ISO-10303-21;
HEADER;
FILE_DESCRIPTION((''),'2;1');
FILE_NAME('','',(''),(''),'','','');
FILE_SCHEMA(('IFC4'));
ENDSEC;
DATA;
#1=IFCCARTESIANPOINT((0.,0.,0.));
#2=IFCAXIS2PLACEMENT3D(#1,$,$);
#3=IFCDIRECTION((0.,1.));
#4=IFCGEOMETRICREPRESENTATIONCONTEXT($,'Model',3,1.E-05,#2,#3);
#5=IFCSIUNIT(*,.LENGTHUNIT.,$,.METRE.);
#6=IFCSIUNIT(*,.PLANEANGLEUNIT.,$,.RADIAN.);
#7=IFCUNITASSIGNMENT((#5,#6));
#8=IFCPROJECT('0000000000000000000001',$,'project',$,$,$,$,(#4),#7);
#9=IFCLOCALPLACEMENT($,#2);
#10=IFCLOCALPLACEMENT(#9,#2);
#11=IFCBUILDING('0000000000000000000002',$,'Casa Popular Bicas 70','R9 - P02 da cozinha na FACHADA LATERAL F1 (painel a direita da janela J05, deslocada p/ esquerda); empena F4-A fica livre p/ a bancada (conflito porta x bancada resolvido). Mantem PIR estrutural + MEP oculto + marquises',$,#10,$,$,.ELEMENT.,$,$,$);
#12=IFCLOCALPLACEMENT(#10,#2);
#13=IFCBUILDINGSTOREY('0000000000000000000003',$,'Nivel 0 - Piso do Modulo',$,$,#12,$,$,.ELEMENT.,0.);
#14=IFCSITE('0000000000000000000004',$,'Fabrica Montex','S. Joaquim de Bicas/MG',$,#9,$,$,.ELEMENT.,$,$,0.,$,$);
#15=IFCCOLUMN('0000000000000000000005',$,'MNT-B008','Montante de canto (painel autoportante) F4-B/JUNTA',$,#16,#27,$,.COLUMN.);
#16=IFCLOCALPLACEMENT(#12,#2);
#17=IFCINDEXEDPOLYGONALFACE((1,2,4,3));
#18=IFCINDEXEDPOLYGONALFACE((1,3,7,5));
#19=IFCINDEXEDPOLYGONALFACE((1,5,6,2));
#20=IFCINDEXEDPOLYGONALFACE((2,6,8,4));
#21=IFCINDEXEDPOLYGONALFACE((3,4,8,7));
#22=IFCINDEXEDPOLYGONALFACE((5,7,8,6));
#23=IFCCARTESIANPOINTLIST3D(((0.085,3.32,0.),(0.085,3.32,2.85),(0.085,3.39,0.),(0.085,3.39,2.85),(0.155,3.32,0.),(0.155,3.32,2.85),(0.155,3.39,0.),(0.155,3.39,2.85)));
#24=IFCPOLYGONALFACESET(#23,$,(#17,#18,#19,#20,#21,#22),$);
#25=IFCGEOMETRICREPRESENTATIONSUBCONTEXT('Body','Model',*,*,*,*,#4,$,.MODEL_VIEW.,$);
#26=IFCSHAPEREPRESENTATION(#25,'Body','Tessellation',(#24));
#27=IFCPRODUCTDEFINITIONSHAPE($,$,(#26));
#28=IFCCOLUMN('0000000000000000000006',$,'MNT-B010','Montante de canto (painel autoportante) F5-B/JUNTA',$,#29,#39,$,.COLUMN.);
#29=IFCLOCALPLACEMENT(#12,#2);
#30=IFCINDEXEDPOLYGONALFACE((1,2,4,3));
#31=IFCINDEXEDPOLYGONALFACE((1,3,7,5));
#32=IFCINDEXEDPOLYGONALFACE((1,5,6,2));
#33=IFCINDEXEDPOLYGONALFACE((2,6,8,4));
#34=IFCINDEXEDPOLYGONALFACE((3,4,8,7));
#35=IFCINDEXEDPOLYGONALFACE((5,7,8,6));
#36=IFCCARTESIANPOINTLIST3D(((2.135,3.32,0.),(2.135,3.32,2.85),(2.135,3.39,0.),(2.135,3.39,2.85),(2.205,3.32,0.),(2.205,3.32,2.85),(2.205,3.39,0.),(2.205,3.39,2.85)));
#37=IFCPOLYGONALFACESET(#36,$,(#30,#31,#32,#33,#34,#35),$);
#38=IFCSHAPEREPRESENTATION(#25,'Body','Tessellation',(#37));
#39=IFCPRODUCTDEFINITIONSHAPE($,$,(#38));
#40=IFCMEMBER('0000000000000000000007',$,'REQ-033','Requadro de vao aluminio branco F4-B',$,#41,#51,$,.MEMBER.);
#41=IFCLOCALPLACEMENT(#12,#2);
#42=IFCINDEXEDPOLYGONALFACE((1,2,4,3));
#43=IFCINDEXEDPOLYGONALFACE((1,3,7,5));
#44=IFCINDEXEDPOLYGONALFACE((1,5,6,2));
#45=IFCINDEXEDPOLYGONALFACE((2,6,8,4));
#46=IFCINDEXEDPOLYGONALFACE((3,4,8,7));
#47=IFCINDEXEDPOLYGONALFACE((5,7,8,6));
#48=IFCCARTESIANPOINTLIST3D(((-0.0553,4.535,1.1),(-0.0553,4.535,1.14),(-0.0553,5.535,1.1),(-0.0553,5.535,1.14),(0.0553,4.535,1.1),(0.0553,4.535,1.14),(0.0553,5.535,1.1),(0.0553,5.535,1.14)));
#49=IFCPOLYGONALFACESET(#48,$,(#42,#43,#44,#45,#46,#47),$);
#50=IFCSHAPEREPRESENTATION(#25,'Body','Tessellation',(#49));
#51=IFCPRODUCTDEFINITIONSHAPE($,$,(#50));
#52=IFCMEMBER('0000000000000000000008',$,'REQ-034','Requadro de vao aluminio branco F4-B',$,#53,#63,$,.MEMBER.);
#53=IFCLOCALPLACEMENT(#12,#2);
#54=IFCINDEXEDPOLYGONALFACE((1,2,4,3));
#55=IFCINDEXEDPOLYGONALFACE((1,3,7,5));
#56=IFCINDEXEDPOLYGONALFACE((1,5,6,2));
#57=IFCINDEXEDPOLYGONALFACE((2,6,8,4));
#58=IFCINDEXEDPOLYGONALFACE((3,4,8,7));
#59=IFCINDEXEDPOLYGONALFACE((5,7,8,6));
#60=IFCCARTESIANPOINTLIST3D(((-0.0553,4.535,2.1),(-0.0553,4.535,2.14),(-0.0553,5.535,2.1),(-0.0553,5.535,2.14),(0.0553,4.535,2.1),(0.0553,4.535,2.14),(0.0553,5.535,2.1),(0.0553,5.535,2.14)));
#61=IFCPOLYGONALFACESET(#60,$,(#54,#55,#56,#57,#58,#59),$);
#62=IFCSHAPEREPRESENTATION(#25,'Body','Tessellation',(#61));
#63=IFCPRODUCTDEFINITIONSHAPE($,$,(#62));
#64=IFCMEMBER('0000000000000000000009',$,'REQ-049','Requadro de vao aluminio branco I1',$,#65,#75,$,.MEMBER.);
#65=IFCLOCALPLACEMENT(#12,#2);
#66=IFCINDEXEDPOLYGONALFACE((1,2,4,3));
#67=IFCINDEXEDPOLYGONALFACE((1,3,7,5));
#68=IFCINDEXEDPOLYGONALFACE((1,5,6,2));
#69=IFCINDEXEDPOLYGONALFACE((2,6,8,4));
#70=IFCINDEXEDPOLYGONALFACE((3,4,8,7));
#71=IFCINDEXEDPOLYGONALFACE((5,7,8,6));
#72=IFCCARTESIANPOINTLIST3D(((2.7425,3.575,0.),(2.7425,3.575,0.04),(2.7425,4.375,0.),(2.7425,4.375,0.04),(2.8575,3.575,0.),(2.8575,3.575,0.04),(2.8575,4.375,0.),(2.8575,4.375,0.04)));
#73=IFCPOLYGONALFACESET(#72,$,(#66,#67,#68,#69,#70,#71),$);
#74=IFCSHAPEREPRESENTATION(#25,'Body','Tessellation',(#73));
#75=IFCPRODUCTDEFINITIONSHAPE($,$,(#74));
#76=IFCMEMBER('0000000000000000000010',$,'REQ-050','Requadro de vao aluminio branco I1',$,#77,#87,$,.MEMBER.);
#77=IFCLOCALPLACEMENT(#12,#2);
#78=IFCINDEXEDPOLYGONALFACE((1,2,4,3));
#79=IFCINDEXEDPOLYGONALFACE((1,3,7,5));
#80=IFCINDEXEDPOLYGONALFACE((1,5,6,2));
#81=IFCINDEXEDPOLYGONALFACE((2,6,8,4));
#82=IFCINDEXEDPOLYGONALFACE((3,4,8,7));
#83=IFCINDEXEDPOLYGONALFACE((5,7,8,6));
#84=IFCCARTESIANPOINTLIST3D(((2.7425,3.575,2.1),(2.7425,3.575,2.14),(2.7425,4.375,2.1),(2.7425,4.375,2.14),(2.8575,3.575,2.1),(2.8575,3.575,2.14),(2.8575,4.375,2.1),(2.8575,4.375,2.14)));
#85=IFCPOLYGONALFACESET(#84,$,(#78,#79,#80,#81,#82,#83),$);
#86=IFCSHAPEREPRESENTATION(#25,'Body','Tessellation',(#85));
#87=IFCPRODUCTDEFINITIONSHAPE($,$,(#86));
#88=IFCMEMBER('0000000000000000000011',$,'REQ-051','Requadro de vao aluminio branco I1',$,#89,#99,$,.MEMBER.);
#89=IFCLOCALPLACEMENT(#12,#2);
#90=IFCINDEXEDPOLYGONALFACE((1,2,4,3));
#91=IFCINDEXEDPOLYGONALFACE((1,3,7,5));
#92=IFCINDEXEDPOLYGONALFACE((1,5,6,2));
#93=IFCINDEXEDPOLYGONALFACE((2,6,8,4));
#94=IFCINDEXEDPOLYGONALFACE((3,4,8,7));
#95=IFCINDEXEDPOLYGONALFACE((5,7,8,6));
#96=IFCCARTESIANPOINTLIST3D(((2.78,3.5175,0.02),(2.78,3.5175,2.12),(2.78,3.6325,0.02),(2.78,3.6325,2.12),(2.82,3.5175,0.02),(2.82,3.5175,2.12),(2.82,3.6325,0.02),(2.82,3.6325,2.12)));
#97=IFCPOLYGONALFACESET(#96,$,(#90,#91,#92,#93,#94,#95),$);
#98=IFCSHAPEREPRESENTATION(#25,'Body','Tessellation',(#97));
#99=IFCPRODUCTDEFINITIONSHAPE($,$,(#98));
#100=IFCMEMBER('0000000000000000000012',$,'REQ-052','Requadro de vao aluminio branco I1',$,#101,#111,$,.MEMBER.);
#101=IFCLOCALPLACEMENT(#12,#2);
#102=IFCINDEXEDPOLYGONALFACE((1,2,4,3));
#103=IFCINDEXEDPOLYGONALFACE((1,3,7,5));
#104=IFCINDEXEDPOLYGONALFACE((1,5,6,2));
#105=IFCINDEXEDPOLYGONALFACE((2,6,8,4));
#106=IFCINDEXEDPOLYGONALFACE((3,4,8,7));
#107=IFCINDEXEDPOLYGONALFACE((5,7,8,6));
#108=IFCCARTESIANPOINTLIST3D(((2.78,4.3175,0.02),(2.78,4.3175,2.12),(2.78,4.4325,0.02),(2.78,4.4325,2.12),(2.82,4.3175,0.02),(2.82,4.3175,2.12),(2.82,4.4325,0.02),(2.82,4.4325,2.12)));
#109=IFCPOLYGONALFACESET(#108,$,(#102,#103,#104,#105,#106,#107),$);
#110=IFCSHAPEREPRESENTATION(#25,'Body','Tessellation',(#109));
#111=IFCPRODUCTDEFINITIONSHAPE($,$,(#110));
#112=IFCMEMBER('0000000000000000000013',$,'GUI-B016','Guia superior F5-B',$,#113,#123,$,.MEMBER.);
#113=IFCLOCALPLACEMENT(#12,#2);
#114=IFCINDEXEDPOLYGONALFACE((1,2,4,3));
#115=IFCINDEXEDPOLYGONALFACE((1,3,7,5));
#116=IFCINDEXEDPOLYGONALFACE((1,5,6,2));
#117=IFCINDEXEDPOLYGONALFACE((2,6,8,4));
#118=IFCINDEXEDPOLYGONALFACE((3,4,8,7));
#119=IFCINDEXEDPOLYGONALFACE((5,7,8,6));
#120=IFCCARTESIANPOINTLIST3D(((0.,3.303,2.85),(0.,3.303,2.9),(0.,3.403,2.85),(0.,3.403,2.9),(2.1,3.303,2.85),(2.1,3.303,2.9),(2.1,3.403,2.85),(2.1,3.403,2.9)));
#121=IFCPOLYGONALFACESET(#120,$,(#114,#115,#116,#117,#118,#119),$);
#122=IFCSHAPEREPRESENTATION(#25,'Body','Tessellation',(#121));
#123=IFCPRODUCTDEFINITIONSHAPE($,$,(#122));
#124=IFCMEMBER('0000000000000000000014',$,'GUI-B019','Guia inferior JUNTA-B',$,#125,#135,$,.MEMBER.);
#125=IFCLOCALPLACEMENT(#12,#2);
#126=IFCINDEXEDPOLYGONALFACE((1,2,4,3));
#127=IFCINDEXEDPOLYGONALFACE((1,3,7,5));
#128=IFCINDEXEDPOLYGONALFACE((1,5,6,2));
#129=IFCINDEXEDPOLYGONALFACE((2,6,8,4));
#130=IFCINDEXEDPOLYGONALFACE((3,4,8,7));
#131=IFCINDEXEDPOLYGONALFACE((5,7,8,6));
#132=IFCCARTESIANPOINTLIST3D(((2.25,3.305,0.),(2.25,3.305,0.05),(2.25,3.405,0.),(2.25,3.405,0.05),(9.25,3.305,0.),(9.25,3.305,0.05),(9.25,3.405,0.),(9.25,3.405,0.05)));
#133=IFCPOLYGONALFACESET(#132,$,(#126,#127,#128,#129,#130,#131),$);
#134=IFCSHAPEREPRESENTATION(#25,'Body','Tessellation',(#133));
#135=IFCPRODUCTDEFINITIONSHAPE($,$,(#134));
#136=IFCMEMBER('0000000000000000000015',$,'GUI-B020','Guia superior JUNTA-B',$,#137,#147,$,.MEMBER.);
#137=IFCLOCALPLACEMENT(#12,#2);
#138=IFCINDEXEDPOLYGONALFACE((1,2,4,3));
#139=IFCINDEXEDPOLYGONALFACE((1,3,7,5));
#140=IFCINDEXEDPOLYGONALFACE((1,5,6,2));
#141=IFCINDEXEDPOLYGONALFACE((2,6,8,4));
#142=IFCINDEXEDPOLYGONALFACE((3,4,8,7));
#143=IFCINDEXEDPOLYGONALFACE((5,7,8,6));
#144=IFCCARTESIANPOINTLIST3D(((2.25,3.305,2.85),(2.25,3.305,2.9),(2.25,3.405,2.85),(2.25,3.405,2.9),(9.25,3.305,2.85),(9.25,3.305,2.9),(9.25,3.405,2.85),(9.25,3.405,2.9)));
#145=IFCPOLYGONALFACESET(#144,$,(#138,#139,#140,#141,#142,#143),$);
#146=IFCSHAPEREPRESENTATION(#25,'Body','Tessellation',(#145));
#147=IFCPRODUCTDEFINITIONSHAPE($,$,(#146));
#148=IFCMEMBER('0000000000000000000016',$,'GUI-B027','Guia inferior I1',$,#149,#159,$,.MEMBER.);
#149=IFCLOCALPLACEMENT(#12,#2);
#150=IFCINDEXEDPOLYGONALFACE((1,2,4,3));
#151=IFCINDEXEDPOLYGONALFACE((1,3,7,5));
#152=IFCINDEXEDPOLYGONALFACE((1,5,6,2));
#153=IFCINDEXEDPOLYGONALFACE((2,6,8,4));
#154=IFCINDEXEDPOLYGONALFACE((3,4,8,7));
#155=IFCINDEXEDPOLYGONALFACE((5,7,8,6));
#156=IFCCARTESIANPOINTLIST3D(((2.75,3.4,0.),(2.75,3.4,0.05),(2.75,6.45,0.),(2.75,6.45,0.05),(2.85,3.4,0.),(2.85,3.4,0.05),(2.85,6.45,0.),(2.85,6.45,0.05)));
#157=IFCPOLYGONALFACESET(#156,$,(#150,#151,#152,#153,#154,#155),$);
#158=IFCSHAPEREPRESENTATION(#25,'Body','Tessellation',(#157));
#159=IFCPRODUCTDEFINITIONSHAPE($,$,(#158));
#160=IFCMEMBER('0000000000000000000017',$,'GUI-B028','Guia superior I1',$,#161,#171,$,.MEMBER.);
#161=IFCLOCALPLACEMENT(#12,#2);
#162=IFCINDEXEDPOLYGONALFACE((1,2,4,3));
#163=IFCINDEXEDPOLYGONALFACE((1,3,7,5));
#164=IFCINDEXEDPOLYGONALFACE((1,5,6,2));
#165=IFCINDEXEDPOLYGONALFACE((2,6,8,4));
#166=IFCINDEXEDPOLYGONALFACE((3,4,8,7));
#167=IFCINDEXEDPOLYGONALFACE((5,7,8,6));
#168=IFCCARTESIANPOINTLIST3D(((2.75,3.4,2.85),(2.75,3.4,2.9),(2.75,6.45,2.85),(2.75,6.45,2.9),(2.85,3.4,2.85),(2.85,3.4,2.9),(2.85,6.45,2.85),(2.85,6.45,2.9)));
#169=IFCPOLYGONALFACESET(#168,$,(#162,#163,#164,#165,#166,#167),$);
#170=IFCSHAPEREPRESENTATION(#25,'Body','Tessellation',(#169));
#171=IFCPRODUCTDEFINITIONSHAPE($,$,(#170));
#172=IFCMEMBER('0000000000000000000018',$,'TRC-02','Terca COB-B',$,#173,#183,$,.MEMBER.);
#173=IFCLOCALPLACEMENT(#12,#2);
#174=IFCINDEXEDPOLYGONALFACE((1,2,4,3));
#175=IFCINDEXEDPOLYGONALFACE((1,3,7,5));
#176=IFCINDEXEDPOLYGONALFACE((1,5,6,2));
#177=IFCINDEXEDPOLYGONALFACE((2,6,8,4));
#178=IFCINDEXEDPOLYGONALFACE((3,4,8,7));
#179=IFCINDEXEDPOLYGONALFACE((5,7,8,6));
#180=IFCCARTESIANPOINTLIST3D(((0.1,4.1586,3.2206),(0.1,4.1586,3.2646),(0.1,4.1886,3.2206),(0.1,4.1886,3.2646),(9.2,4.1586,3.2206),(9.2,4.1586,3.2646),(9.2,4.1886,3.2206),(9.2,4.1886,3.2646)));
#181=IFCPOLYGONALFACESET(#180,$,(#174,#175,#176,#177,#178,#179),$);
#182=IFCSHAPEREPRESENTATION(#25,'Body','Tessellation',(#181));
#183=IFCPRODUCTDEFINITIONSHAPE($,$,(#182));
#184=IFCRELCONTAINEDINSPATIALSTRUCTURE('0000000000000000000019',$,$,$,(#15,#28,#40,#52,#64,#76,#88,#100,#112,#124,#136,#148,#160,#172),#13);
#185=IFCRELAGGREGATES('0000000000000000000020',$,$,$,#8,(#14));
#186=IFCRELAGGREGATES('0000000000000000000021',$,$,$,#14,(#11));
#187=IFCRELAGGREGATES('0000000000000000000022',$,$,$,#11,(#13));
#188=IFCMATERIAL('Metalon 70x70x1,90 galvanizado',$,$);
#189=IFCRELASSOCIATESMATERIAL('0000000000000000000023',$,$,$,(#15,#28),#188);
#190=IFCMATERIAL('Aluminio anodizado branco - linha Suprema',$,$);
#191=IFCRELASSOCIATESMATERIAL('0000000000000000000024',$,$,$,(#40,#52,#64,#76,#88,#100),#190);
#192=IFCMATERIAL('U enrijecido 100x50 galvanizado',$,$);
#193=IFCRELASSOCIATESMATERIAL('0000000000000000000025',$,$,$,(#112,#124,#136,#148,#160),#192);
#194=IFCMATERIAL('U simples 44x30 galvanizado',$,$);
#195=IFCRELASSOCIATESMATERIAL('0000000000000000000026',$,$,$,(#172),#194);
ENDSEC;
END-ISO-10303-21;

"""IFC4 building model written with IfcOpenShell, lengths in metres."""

from ifc_helpers import new_model, si_unit, direction, frame, origin, origin_2d, place, context, subcontext, project, spatial, rectangle, extrude, material, element, save


model = new_model("IFC4")

# Units and contexts
model_context = context("Model", 3, precision=1e-05, world=origin(), true_north=direction((0.0, 1.0)))
body_context = subcontext(model_context, "Body", "Model", "MODEL_VIEW")
ifc_project = project(units=[si_unit("LENGTHUNIT", "METRE"), si_unit("PLANEANGLEUNIT", "RADIAN")], contexts=[model_context])

# Site, building, storey
site_placement = place(None, origin())
site = spatial("IfcSite", under=ifc_project, at=site_placement, Name="Fabrica Montex", Description="S. Joaquim de Bicas/MG", CompositionType="ELEMENT", RefElevation=0.0)
building_placement = place(site_placement, origin())
building = spatial("IfcBuilding", under=site, at=building_placement, Name="Casa Popular Bicas 70", Description="R9 - P02 da cozinha na FACHADA LATERAL F1 (painel a direita da janela J05, deslocada p/ esquerda); empena F4-A fica livre p/ a bancada (conflito porta x bancada resolvido). Mantem PIR estrutural + MEP oculto + marquises", CompositionType="ELEMENT")
storey_placement = place(building_placement, origin())
storey = spatial("IfcBuildingStorey", under=building, at=storey_placement, Name="Nivel 0 - Piso do Modulo", CompositionType="ELEMENT", Elevation=0.0)

# Columns
ifc_material_1 = material(Name="Metalon 70x70x1,90 galvanizado")
for number, where, name, description in (
    (1, (0.12, 3.355, 0.0), "MNT-B008", "Montante de canto (painel autoportante) F4-B/JUNTA"),
    (2, (2.17, 3.355, 0.0), "MNT-B010", "Montante de canto (painel autoportante) F5-B/JUNTA"),
):
    element("IfcColumn", number, at=place(storey_placement, frame(where)), inside=storey, material=ifc_material_1, Name=name, Description=description, PredefinedType="COLUMN", context=body_context, shape_type="SweptSolid", body=[
        extrude(rectangle(XDim=0.07, YDim=0.07, at=origin_2d()), origin(), (0.0, 0.0, 1.0), 2.85),
    ])

# Members
ifc_material_2 = material(Name="Aluminio anodizado branco - linha Suprema")
for number, where, z_axis, x_axis, name in (
    (3, (0.0, 4.535, 1.12), (0.0, 1.0, 0.0), (0.0, 0.0, 1.0), "REQ-033"),
    (4, (0.0, 4.535, 2.12), (0.0, 1.0, 0.0), (0.0, 0.0, 1.0), "REQ-034"),
):
    element("IfcMember", number, at=place(storey_placement, frame(where, z_axis=z_axis, x_axis=x_axis)), inside=storey, material=ifc_material_2, Name=name, Description="Requadro de vao aluminio branco F4-B", PredefinedType="MEMBER", context=body_context, shape_type="SweptSolid", body=[
        extrude(rectangle(XDim=0.04, YDim=0.1105, at=origin_2d()), origin(), (0.0, 0.0, 1.0), 1.0),
    ])
for number, where, z_axis, x_axis, name in (
    (5, (2.8, 3.575, 0.02), (0.0, 1.0, 0.0), (0.0, 0.0, 1.0), "REQ-049"),
    (6, (2.8, 3.575, 2.12), (0.0, 1.0, 0.0), (0.0, 0.0, 1.0), "REQ-050"),
):
    element("IfcMember", number, at=place(storey_placement, frame(where, z_axis=z_axis, x_axis=x_axis)), inside=storey, material=ifc_material_2, Name=name, Description="Requadro de vao aluminio branco I1", PredefinedType="MEMBER", context=body_context, shape_type="SweptSolid", body=[
        extrude(rectangle(XDim=0.04, YDim=0.115, at=origin_2d()), origin(), (0.0, 0.0, 1.0), 0.8),
    ])
for number, where, z_axis, x_axis, name in (
    (7, (2.8, 3.575, 0.02), (0.0, 0.0, 1.0), (1.0, 0.0, 0.0), "REQ-051"),
    (8, (2.8, 4.375, 0.02), (0.0, 0.0, 1.0), (1.0, 0.0, 0.0), "REQ-052"),
):
    element("IfcMember", number, at=place(storey_placement, frame(where, z_axis=z_axis, x_axis=x_axis)), inside=storey, material=ifc_material_2, Name=name, Description="Requadro de vao aluminio branco I1", PredefinedType="MEMBER", context=body_context, shape_type="SweptSolid", body=[
        extrude(rectangle(XDim=0.04, YDim=0.115, at=origin_2d()), origin(), (0.0, 0.0, 1.0), 2.1),
    ])
ifc_material_3 = material(Name="U enrijecido 100x50 galvanizado")
member_1_placement = place(storey_placement, frame((0.0, 3.353, 2.875), z_axis=(1.0, 0.0, 0.0), x_axis=(0.0, 0.0, 1.0)))
element("IfcMember", 9, at=member_1_placement, inside=storey, material=ifc_material_3, Name="GUI-B016", Description="Guia superior F5-B", PredefinedType="MEMBER", context=body_context, shape_type="SweptSolid", body=[
    extrude(rectangle(XDim=0.05, YDim=0.1, at=origin_2d()), origin(), (0.0, 0.0, 1.0), 2.1),
])
for number, where, z_axis, x_axis, name, description in (
    (10, (2.25, 3.355, 0.025), (1.0, 0.0, 0.0), (0.0, 0.0, 1.0), "GUI-B019", "Guia inferior JUNTA-B"),
    (11, (2.25, 3.355, 2.875), (1.0, 0.0, 0.0), (0.0, 0.0, 1.0), "GUI-B020", "Guia superior JUNTA-B"),
):
    element("IfcMember", number, at=place(storey_placement, frame(where, z_axis=z_axis, x_axis=x_axis)), inside=storey, material=ifc_material_3, Name=name, Description=description, PredefinedType="MEMBER", context=body_context, shape_type="SweptSolid", body=[
        extrude(rectangle(XDim=0.05, YDim=0.1, at=origin_2d()), origin(), (0.0, 0.0, 1.0), 7.0),
    ])
for number, where, z_axis, x_axis, name, description in (
    (12, (2.8, 3.4, 0.025), (0.0, 1.0, 0.0), (0.0, 0.0, 1.0), "GUI-B027", "Guia inferior I1"),
    (13, (2.8, 3.4, 2.875), (0.0, 1.0, 0.0), (0.0, 0.0, 1.0), "GUI-B028", "Guia superior I1"),
):
    element("IfcMember", number, at=place(storey_placement, frame(where, z_axis=z_axis, x_axis=x_axis)), inside=storey, material=ifc_material_3, Name=name, Description=description, PredefinedType="MEMBER", context=body_context, shape_type="SweptSolid", body=[
        extrude(rectangle(XDim=0.05, YDim=0.1, at=origin_2d()), origin(), (0.0, 0.0, 1.0), 3.05),
    ])
ifc_material_4 = material(Name="U simples 44x30 galvanizado")
member_2_placement = place(storey_placement, frame((0.1, 4.1736, 3.2426), z_axis=(1.0, 0.0, 0.0), x_axis=(0.0, 0.0, 1.0)))
element("IfcMember", 14, at=member_2_placement, inside=storey, material=ifc_material_4, Name="TRC-02", Description="Terca COB-B", PredefinedType="MEMBER", context=body_context, shape_type="SweptSolid", body=[
    extrude(rectangle(XDim=0.044, YDim=0.03, at=origin_2d()), origin(), (0.0, 0.0, 1.0), 9.1),
])

save(model, "model.ifc")
